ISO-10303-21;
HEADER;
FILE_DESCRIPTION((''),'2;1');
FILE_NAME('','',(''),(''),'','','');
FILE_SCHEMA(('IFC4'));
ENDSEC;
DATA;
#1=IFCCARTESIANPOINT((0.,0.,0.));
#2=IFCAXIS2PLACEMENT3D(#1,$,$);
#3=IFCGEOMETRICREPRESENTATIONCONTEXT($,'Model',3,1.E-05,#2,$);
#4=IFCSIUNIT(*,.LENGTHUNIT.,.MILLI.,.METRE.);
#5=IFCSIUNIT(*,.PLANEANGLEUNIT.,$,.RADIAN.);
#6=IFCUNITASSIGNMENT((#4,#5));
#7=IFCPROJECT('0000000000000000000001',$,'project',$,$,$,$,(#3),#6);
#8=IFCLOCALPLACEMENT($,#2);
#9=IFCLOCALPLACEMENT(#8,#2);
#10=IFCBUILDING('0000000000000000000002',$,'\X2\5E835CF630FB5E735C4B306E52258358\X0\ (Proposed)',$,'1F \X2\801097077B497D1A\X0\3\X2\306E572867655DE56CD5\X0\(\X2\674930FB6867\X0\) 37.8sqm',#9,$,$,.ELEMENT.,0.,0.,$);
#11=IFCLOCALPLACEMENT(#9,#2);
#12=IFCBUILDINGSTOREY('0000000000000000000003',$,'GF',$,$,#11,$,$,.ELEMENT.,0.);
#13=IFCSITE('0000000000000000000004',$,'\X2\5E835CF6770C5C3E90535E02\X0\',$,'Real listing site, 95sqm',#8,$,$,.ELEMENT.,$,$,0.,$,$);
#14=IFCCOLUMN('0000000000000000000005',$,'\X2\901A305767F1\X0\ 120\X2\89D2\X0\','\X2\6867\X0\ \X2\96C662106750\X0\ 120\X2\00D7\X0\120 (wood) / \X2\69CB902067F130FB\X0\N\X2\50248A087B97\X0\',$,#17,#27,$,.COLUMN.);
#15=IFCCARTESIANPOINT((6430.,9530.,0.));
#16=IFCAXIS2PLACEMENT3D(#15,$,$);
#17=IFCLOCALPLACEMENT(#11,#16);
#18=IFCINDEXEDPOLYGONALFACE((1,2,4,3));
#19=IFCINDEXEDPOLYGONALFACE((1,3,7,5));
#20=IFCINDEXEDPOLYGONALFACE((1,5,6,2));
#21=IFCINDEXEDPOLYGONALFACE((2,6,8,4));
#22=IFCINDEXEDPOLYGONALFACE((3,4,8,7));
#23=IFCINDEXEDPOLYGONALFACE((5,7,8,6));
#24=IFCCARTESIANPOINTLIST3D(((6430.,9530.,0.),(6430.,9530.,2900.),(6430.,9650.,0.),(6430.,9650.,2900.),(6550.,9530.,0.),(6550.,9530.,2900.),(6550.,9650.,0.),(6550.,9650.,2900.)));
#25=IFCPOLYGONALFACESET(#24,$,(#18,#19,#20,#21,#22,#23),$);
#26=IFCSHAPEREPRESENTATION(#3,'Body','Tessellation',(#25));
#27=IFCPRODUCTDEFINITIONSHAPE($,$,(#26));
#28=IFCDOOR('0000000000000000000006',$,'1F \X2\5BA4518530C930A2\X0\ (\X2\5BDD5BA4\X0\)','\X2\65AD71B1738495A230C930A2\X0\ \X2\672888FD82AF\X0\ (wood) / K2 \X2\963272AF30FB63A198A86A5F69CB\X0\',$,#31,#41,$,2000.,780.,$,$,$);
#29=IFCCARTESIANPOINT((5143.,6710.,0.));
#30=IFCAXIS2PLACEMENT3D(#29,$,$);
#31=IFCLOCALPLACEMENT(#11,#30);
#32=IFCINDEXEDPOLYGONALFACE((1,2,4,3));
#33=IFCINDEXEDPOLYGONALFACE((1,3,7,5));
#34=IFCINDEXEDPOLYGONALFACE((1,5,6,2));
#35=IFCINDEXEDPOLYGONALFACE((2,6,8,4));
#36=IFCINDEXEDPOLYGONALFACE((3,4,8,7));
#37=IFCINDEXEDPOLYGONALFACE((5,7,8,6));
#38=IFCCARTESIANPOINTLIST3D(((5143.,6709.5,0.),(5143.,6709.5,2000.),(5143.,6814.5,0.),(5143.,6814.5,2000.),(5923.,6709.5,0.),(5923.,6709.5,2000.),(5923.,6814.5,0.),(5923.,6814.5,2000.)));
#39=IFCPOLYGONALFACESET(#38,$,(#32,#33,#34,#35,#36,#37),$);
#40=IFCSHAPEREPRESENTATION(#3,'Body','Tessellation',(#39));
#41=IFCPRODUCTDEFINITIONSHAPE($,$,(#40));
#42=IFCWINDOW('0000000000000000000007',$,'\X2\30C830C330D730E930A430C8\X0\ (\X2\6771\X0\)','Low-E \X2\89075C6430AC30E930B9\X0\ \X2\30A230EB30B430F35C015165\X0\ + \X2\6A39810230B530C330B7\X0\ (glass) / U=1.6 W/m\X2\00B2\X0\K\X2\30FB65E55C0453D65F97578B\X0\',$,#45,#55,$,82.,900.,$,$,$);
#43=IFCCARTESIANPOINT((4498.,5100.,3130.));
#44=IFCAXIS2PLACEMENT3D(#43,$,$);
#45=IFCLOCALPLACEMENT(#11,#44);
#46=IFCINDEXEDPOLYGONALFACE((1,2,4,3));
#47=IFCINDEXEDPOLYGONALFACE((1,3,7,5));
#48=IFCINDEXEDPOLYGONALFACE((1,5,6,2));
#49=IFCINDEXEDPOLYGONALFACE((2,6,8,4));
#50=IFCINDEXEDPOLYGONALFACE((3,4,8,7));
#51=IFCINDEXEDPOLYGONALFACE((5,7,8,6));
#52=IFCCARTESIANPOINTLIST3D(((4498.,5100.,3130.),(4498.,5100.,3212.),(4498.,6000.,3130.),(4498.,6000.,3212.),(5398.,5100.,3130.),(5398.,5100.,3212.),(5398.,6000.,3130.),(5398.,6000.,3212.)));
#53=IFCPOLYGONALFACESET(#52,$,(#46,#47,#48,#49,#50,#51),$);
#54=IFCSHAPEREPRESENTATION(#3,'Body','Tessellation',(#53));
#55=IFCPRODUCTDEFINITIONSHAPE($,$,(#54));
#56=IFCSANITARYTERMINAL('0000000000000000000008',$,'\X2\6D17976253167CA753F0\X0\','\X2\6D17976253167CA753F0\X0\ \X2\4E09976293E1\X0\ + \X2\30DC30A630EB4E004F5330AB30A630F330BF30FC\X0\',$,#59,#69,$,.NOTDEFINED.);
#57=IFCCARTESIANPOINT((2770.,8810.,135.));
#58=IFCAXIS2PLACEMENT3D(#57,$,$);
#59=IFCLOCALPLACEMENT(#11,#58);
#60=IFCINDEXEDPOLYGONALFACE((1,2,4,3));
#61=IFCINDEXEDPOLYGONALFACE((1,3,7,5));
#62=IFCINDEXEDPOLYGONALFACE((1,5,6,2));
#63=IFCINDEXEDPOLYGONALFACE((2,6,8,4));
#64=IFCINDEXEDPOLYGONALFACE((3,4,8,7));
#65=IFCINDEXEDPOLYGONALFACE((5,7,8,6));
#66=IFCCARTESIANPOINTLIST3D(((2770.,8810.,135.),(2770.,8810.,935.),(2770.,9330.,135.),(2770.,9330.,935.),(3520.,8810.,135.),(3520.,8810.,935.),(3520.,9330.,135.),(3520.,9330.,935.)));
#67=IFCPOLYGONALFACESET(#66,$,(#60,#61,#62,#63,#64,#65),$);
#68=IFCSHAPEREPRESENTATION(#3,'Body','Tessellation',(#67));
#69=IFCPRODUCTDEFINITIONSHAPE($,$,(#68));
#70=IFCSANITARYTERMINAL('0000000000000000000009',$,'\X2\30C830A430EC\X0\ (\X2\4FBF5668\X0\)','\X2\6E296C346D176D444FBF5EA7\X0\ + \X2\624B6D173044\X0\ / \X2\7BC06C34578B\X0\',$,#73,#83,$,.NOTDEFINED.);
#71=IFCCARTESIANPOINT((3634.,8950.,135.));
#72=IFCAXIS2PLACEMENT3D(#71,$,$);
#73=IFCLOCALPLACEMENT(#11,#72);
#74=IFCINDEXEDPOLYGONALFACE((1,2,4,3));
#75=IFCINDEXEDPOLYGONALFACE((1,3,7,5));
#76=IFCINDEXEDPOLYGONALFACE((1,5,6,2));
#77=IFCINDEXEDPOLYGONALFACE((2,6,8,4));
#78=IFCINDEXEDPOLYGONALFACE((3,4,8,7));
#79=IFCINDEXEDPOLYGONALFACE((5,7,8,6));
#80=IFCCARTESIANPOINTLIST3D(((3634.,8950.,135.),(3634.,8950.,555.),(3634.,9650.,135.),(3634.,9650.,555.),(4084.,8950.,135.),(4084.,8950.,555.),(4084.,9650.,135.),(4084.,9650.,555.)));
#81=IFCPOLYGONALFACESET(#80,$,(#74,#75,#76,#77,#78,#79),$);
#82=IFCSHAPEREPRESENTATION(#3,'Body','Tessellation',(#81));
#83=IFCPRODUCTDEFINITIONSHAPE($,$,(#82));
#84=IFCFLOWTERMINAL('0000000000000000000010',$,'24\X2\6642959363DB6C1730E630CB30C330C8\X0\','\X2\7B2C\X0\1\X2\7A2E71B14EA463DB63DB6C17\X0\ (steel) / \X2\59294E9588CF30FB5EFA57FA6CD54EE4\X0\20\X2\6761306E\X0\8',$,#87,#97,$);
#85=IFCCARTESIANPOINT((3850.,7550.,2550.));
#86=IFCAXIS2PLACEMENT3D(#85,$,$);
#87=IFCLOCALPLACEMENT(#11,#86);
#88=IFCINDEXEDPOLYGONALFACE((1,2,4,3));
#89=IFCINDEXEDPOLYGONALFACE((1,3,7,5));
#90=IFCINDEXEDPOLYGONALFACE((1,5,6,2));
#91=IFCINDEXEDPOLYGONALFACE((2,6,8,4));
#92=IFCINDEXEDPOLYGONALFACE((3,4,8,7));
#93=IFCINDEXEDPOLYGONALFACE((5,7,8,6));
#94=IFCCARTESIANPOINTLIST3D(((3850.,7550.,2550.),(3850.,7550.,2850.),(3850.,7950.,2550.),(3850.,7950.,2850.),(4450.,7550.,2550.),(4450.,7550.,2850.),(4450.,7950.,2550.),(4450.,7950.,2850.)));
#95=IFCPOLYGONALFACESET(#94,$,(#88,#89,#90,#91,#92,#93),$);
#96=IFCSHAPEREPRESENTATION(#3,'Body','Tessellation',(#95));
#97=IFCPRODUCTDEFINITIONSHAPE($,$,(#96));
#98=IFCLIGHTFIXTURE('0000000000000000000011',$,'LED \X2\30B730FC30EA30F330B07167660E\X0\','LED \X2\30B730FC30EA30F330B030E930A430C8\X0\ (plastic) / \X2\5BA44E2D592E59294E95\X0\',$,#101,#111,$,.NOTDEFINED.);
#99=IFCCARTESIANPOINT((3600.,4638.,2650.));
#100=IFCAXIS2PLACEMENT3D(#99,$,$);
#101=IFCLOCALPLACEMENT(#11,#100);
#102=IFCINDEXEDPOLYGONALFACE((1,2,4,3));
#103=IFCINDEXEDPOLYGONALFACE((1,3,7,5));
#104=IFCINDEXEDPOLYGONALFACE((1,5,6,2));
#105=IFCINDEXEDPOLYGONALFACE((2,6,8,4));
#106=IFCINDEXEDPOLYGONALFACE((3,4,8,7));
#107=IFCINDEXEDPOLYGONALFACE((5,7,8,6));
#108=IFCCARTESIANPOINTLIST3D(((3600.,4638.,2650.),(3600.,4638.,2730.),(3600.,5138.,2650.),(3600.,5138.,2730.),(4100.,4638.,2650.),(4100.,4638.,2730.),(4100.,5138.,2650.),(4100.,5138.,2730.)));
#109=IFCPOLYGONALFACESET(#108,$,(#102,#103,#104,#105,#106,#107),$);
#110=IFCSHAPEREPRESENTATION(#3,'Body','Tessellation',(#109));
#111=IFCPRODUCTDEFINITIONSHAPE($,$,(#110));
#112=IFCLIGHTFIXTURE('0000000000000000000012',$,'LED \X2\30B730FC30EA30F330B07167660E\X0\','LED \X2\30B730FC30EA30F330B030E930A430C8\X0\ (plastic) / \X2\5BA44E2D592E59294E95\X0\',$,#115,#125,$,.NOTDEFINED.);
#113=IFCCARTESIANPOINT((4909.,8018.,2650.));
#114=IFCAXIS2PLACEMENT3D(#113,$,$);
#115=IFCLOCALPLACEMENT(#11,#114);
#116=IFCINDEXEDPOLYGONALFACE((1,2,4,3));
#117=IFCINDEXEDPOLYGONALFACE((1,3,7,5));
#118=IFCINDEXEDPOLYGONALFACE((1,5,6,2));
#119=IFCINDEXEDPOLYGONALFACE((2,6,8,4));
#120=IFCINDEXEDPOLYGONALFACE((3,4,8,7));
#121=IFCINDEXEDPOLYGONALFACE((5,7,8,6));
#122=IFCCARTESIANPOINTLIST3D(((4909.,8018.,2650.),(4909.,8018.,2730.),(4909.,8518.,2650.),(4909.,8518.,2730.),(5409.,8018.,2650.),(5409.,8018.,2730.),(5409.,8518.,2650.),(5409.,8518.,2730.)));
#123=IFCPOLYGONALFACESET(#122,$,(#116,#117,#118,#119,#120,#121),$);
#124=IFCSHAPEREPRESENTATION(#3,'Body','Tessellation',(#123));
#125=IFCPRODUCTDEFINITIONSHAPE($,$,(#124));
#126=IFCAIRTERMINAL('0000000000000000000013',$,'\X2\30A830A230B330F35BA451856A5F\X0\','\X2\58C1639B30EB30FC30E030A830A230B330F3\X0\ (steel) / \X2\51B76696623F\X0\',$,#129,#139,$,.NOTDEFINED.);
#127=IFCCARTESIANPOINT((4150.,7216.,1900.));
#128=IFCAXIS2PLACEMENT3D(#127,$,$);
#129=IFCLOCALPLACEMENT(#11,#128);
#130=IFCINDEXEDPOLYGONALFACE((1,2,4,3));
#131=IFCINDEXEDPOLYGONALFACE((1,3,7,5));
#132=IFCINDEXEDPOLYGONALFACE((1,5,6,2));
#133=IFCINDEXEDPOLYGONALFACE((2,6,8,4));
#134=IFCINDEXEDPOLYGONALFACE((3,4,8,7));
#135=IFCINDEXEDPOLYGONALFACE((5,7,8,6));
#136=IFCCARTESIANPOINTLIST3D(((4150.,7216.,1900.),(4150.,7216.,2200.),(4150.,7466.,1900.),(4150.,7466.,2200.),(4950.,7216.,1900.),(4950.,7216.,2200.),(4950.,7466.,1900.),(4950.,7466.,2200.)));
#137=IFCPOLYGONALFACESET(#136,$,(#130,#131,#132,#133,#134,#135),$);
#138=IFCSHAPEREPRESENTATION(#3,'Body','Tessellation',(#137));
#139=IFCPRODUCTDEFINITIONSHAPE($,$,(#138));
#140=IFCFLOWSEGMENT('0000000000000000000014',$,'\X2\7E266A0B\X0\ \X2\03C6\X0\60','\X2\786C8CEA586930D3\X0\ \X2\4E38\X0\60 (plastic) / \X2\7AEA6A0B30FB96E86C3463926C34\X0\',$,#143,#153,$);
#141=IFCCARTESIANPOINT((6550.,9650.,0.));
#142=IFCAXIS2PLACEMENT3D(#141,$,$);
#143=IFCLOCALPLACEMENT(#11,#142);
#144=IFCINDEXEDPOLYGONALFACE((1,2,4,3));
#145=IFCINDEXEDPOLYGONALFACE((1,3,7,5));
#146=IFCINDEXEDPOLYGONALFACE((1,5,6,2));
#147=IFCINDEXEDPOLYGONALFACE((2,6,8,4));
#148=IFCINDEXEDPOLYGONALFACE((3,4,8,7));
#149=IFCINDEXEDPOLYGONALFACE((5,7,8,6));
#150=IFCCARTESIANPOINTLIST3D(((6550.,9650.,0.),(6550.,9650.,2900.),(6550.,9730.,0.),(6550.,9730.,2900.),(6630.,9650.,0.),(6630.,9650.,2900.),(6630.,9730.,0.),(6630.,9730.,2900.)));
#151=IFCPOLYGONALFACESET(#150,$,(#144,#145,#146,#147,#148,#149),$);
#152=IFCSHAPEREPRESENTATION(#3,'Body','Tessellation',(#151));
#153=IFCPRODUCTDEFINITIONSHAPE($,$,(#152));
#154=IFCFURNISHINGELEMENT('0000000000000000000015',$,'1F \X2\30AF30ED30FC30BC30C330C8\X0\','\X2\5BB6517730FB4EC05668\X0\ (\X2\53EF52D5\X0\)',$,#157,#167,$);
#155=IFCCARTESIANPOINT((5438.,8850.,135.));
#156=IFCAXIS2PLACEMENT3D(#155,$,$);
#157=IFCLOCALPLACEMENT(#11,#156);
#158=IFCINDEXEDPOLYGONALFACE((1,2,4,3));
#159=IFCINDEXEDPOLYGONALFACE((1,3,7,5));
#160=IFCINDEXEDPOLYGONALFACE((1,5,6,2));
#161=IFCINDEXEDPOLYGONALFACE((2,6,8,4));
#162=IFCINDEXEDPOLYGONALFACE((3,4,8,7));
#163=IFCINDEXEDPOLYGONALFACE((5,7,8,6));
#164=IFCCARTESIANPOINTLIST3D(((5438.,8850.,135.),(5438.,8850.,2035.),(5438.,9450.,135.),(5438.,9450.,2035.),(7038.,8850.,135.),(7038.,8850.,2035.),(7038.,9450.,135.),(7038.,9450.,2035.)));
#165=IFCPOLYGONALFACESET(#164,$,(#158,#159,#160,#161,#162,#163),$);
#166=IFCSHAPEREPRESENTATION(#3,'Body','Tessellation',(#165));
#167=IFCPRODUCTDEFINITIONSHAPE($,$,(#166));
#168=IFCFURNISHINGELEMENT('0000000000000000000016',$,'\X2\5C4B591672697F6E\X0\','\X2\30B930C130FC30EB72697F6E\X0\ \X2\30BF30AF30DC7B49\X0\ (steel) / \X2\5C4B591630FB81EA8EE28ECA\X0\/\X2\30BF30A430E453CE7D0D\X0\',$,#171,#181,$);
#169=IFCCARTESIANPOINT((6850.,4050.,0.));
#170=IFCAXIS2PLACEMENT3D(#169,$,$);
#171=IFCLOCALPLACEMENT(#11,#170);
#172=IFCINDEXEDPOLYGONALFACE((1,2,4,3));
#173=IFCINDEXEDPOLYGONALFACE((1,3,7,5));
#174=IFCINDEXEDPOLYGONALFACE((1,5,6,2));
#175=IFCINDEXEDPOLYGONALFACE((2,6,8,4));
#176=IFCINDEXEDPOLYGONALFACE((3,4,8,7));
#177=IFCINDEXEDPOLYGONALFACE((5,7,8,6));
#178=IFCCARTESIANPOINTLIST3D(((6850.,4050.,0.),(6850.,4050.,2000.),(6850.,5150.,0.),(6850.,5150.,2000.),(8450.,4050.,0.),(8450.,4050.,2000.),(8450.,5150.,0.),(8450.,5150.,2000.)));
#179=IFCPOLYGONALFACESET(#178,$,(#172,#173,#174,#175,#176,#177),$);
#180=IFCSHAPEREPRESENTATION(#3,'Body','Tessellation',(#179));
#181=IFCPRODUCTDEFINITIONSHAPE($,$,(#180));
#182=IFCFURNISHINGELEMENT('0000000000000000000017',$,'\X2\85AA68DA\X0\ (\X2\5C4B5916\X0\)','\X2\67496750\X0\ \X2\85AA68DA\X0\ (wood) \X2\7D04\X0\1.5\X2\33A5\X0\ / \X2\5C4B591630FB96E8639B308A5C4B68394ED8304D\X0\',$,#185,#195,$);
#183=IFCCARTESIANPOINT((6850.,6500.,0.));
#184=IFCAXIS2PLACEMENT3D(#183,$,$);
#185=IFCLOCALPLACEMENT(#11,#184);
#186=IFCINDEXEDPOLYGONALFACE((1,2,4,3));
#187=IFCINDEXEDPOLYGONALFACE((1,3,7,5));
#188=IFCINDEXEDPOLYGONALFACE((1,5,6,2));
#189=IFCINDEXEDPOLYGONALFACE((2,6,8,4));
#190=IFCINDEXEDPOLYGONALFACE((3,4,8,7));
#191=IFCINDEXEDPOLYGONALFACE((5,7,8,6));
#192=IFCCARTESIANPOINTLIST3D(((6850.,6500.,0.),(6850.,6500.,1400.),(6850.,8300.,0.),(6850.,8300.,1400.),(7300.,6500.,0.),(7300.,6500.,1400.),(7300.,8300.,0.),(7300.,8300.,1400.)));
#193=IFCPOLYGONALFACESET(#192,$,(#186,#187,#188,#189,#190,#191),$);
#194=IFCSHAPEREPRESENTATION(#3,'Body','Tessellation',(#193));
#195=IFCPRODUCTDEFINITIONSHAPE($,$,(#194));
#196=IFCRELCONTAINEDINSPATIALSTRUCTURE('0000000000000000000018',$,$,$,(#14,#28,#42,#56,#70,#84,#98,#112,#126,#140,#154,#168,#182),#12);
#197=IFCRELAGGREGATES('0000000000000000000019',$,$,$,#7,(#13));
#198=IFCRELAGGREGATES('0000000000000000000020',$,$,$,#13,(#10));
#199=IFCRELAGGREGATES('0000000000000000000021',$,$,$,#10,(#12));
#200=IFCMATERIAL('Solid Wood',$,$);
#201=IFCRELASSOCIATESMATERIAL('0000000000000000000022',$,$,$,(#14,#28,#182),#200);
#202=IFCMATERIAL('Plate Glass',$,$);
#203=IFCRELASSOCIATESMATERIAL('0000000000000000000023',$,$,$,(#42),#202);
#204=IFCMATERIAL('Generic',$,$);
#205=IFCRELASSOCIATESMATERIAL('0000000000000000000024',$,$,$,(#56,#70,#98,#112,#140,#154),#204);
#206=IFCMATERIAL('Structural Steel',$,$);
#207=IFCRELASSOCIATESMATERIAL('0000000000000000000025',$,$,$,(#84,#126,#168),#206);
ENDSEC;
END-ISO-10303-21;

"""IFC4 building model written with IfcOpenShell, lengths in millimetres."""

from ifc_helpers import new_model, si_unit, frame, frame_2d, origin, place, context, project, spatial, rectangle, extrude, material, element, save


model = new_model("IFC4")

# Units and contexts
model_context = context("Model", 3, precision=1e-05, world=origin())
ifc_project = project(units=[si_unit("LENGTHUNIT", "METRE", prefix="MILLI"), si_unit("PLANEANGLEUNIT", "RADIAN")], contexts=[model_context])

# Site, building, storey
site_placement = place(None, origin())
site = spatial("IfcSite", under=ifc_project, at=site_placement, Name="広島県尾道市", ObjectType="Real listing site, 95sqm", CompositionType="ELEMENT", RefElevation=0.0)
building_placement = place(site_placement, origin())
building = spatial("IfcBuilding", under=site, at=building_placement, Name="広島・平屋の別荘 (Proposed)", ObjectType="1F 耐震等級3の在来工法(杉・桧) 37.8sqm", CompositionType="ELEMENT", ElevationOfRefHeight=0.0, ElevationOfTerrain=0.0)
storey_placement = place(building_placement, origin())
storey = spatial("IfcBuildingStorey", under=building, at=storey_placement, Name="GF", CompositionType="ELEMENT", Elevation=0.0)

# Column
ifc_material_1 = material(Name="Solid Wood")
column_1_placement = place(storey_placement, frame((6430.0, 9530.0, 0.0)))
element("IfcColumn", 1, at=column_1_placement, inside=storey, material=ifc_material_1, Name="通し柱 120角", Description="桧 集成材 120×120 (wood) / 構造柱・N値計算", PredefinedType="COLUMN", context=model_context, shape_type="SweptSolid", body=[
    extrude(rectangle(XDim=120.0, YDim=120.0, at=frame_2d((60.0, 60.0))), frame((6430.0, 9530.0, 0.0)), (0.0, 0.0, 1.0), 2900.0),
])

# Door
door_placement = place(storey_placement, frame((5143.0, 6710.0, 0.0)))
element("IfcDoor", 2, at=door_placement, inside=storey, material=ifc_material_1, Name="1F 室内ドア (寝室)", Description="断熱玄関ドア 木製芯 (wood) / K2 防犯・採風機構", OverallHeight=2000.0, OverallWidth=780.0, context=model_context, shape_type="SweptSolid", body=[
    extrude(rectangle(XDim=780.0, YDim=105.0, at=frame_2d((390.0, 52.0))), frame((5143.0, 6710.0, 0.0)), (0.0, 0.0, 1.0), 2000.0),
])

# Window
ifc_material_2 = material(Name="Plate Glass")
window_placement = place(storey_placement, frame((4498.0, 5100.0, 3130.0)))
element("IfcWindow", 3, at=window_placement, inside=storey, material=ifc_material_2, Name="トップライト (東)", Description="Low-E 複層ガラス アルゴン封入 + 樹脂サッシ (glass) / U=1.6 W/m²K・日射取得型", OverallHeight=82.0, OverallWidth=900.0, context=model_context, shape_type="SweptSolid", body=[
    extrude(rectangle(XDim=900.0, YDim=900.0, at=frame_2d((450.0, 450.0))), frame((4498.0, 5100.0, 3130.0)), (0.0, 0.0, 1.0), 82.0),
])

# Sanitary terminals
ifc_material_3 = material(Name="Generic")
sanitary_terminal_1_placement = place(storey_placement, frame((2770.0, 8810.0, 135.0)))
element("IfcSanitaryTerminal", 4, at=sanitary_terminal_1_placement, inside=storey, material=ifc_material_3, Name="洗面化粧台", Description="洗面化粧台 三面鏡 + ボウル一体カウンター", PredefinedType="NOTDEFINED", context=model_context, shape_type="SweptSolid", body=[
    extrude(rectangle(XDim=750.0, YDim=520.0, at=frame_2d((375.0, 260.0))), frame((2770.0, 8810.0, 135.0)), (0.0, 0.0, 1.0), 800.0),
])
sanitary_terminal_2_placement = place(storey_placement, frame((3634.0, 8950.0, 135.0)))
element("IfcSanitaryTerminal", 5, at=sanitary_terminal_2_placement, inside=storey, material=ifc_material_3, Name="トイレ (便器)", Description="温水洗浄便座 + 手洗い / 節水型", PredefinedType="NOTDEFINED", context=model_context, shape_type="SweptSolid", body=[
    extrude(rectangle(XDim=450.0, YDim=700.0, at=frame_2d((225.0, 350.0))), frame((3634.0, 8950.0, 135.0)), (0.0, 0.0, 1.0), 420.0),
])

# Flow terminal
ifc_material_4 = material(Name="Structural Steel")
flow_terminal_placement = place(storey_placement, frame((3850.0, 7550.0, 2550.0)))
element("IfcFlowTerminal", 6, at=flow_terminal_placement, inside=storey, material=ifc_material_4, Name="24時間換気ユニット", Description="第1種熱交換換気 (steel) / 天井裏・建基法令20条の8", context=model_context, shape_type="SweptSolid", body=[
    extrude(rectangle(XDim=600.0, YDim=400.0, at=frame_2d((300.0, 200.0))), frame((3850.0, 7550.0, 2550.0)), (0.0, 0.0, 1.0), 300.0),
])

# Light fixtures
light_fixture_1_placement = place(storey_placement, frame((3600.0, 4638.0, 2650.0)))
element("IfcLightFixture", 7, at=light_fixture_1_placement, inside=storey, material=ifc_material_3, Name="LED シーリング照明", Description="LED シーリングライト (plastic) / 室中央天井", PredefinedType="NOTDEFINED", context=model_context, shape_type="SweptSolid", body=[
    extrude(rectangle(XDim=500.0, YDim=500.0, at=frame_2d((250.0, 250.0))), frame((3600.0, 4638.0, 2650.0)), (0.0, 0.0, 1.0), 80.0),
])
light_fixture_2_placement = place(storey_placement, frame((4909.0, 8018.0, 2650.0)))
element("IfcLightFixture", 8, at=light_fixture_2_placement, inside=storey, material=ifc_material_3, Name="LED シーリング照明", Description="LED シーリングライト (plastic) / 室中央天井", PredefinedType="NOTDEFINED", context=model_context, shape_type="SweptSolid", body=[
    extrude(rectangle(XDim=500.0, YDim=500.0, at=frame_2d((250.0, 250.0))), frame((4909.0, 8018.0, 2650.0)), (0.0, 0.0, 1.0), 80.0),
])

# Air terminal
air_terminal_placement = place(storey_placement, frame((4150.0, 7216.0, 1900.0)))
element("IfcAirTerminal", 9, at=air_terminal_placement, inside=storey, material=ifc_material_4, Name="エアコン室内機", Description="壁掛ルームエアコン (steel) / 冷暖房", PredefinedType="NOTDEFINED", context=model_context, shape_type="SweptSolid", body=[
    extrude(rectangle(XDim=800.0, YDim=250.0, at=frame_2d((400.0, 125.0))), frame((4150.0, 7216.0, 1900.0)), (0.0, 0.0, 1.0), 300.0),
])

# Flow segment
flow_segment_placement = place(storey_placement, frame((6550.0, 9650.0, 0.0)))
element("IfcFlowSegment", 10, at=flow_segment_placement, inside=storey, material=ifc_material_3, Name="縦樋 φ60", Description="硬質塩ビ 丸60 (plastic) / 竪樋・雨水排水", context=model_context, shape_type="SweptSolid", body=[
    extrude(rectangle(XDim=80.0, YDim=80.0, at=frame_2d((40.0, 40.0))), frame((6550.0, 9650.0, 0.0)), (0.0, 0.0, 1.0), 2900.0),
])

# Furnishing elements
furnishing_1_placement = place(storey_placement, frame((5438.0, 8850.0, 135.0)))
element("IfcFurnishingElement", 11, at=furnishing_1_placement, inside=storey, material=ifc_material_3, Name="1F クローゼット", Description="家具・什器 (可動)", context=model_context, shape_type="SweptSolid", body=[
    extrude(rectangle(XDim=1600.0, YDim=600.0, at=frame_2d((800.0, 300.0))), frame((5438.0, 8850.0, 135.0)), (0.0, 0.0, 1.0), 1900.0),
])
furnishing_2_placement = place(storey_placement, frame((6850.0, 4050.0, 0.0)))
element("IfcFurnishingElement", 12, at=furnishing_2_placement, inside=storey, material=ifc_material_4, Name="屋外物置", Description="スチール物置 タクボ等 (steel) / 屋外・自転車/タイヤ収納", context=model_context, shape_type="SweptSolid", body=[
    extrude(rectangle(XDim=1600.0, YDim=1100.0, at=frame_2d((800.0, 550.0))), frame((6850.0, 4050.0, 0.0)), (0.0, 0.0, 1.0), 2000.0),
])
furnishing_3_placement = place(storey_placement, frame((6850.0, 6500.0, 0.0)))
element("IfcFurnishingElement", 13, at=furnishing_3_placement, inside=storey, material=ifc_material_1, Name="薪棚 (屋外)", Description="杉材 薪棚 (wood) 約1.5㎥ / 屋外・雨掛り屋根付き", context=model_context, shape_type="SweptSolid", body=[
    extrude(rectangle(XDim=450.0, YDim=1800.0, at=frame_2d((225.0, 900.0))), frame((6850.0, 6500.0, 0.0)), (0.0, 0.0, 1.0), 1400.0),
])

save(model, "model.ifc")
